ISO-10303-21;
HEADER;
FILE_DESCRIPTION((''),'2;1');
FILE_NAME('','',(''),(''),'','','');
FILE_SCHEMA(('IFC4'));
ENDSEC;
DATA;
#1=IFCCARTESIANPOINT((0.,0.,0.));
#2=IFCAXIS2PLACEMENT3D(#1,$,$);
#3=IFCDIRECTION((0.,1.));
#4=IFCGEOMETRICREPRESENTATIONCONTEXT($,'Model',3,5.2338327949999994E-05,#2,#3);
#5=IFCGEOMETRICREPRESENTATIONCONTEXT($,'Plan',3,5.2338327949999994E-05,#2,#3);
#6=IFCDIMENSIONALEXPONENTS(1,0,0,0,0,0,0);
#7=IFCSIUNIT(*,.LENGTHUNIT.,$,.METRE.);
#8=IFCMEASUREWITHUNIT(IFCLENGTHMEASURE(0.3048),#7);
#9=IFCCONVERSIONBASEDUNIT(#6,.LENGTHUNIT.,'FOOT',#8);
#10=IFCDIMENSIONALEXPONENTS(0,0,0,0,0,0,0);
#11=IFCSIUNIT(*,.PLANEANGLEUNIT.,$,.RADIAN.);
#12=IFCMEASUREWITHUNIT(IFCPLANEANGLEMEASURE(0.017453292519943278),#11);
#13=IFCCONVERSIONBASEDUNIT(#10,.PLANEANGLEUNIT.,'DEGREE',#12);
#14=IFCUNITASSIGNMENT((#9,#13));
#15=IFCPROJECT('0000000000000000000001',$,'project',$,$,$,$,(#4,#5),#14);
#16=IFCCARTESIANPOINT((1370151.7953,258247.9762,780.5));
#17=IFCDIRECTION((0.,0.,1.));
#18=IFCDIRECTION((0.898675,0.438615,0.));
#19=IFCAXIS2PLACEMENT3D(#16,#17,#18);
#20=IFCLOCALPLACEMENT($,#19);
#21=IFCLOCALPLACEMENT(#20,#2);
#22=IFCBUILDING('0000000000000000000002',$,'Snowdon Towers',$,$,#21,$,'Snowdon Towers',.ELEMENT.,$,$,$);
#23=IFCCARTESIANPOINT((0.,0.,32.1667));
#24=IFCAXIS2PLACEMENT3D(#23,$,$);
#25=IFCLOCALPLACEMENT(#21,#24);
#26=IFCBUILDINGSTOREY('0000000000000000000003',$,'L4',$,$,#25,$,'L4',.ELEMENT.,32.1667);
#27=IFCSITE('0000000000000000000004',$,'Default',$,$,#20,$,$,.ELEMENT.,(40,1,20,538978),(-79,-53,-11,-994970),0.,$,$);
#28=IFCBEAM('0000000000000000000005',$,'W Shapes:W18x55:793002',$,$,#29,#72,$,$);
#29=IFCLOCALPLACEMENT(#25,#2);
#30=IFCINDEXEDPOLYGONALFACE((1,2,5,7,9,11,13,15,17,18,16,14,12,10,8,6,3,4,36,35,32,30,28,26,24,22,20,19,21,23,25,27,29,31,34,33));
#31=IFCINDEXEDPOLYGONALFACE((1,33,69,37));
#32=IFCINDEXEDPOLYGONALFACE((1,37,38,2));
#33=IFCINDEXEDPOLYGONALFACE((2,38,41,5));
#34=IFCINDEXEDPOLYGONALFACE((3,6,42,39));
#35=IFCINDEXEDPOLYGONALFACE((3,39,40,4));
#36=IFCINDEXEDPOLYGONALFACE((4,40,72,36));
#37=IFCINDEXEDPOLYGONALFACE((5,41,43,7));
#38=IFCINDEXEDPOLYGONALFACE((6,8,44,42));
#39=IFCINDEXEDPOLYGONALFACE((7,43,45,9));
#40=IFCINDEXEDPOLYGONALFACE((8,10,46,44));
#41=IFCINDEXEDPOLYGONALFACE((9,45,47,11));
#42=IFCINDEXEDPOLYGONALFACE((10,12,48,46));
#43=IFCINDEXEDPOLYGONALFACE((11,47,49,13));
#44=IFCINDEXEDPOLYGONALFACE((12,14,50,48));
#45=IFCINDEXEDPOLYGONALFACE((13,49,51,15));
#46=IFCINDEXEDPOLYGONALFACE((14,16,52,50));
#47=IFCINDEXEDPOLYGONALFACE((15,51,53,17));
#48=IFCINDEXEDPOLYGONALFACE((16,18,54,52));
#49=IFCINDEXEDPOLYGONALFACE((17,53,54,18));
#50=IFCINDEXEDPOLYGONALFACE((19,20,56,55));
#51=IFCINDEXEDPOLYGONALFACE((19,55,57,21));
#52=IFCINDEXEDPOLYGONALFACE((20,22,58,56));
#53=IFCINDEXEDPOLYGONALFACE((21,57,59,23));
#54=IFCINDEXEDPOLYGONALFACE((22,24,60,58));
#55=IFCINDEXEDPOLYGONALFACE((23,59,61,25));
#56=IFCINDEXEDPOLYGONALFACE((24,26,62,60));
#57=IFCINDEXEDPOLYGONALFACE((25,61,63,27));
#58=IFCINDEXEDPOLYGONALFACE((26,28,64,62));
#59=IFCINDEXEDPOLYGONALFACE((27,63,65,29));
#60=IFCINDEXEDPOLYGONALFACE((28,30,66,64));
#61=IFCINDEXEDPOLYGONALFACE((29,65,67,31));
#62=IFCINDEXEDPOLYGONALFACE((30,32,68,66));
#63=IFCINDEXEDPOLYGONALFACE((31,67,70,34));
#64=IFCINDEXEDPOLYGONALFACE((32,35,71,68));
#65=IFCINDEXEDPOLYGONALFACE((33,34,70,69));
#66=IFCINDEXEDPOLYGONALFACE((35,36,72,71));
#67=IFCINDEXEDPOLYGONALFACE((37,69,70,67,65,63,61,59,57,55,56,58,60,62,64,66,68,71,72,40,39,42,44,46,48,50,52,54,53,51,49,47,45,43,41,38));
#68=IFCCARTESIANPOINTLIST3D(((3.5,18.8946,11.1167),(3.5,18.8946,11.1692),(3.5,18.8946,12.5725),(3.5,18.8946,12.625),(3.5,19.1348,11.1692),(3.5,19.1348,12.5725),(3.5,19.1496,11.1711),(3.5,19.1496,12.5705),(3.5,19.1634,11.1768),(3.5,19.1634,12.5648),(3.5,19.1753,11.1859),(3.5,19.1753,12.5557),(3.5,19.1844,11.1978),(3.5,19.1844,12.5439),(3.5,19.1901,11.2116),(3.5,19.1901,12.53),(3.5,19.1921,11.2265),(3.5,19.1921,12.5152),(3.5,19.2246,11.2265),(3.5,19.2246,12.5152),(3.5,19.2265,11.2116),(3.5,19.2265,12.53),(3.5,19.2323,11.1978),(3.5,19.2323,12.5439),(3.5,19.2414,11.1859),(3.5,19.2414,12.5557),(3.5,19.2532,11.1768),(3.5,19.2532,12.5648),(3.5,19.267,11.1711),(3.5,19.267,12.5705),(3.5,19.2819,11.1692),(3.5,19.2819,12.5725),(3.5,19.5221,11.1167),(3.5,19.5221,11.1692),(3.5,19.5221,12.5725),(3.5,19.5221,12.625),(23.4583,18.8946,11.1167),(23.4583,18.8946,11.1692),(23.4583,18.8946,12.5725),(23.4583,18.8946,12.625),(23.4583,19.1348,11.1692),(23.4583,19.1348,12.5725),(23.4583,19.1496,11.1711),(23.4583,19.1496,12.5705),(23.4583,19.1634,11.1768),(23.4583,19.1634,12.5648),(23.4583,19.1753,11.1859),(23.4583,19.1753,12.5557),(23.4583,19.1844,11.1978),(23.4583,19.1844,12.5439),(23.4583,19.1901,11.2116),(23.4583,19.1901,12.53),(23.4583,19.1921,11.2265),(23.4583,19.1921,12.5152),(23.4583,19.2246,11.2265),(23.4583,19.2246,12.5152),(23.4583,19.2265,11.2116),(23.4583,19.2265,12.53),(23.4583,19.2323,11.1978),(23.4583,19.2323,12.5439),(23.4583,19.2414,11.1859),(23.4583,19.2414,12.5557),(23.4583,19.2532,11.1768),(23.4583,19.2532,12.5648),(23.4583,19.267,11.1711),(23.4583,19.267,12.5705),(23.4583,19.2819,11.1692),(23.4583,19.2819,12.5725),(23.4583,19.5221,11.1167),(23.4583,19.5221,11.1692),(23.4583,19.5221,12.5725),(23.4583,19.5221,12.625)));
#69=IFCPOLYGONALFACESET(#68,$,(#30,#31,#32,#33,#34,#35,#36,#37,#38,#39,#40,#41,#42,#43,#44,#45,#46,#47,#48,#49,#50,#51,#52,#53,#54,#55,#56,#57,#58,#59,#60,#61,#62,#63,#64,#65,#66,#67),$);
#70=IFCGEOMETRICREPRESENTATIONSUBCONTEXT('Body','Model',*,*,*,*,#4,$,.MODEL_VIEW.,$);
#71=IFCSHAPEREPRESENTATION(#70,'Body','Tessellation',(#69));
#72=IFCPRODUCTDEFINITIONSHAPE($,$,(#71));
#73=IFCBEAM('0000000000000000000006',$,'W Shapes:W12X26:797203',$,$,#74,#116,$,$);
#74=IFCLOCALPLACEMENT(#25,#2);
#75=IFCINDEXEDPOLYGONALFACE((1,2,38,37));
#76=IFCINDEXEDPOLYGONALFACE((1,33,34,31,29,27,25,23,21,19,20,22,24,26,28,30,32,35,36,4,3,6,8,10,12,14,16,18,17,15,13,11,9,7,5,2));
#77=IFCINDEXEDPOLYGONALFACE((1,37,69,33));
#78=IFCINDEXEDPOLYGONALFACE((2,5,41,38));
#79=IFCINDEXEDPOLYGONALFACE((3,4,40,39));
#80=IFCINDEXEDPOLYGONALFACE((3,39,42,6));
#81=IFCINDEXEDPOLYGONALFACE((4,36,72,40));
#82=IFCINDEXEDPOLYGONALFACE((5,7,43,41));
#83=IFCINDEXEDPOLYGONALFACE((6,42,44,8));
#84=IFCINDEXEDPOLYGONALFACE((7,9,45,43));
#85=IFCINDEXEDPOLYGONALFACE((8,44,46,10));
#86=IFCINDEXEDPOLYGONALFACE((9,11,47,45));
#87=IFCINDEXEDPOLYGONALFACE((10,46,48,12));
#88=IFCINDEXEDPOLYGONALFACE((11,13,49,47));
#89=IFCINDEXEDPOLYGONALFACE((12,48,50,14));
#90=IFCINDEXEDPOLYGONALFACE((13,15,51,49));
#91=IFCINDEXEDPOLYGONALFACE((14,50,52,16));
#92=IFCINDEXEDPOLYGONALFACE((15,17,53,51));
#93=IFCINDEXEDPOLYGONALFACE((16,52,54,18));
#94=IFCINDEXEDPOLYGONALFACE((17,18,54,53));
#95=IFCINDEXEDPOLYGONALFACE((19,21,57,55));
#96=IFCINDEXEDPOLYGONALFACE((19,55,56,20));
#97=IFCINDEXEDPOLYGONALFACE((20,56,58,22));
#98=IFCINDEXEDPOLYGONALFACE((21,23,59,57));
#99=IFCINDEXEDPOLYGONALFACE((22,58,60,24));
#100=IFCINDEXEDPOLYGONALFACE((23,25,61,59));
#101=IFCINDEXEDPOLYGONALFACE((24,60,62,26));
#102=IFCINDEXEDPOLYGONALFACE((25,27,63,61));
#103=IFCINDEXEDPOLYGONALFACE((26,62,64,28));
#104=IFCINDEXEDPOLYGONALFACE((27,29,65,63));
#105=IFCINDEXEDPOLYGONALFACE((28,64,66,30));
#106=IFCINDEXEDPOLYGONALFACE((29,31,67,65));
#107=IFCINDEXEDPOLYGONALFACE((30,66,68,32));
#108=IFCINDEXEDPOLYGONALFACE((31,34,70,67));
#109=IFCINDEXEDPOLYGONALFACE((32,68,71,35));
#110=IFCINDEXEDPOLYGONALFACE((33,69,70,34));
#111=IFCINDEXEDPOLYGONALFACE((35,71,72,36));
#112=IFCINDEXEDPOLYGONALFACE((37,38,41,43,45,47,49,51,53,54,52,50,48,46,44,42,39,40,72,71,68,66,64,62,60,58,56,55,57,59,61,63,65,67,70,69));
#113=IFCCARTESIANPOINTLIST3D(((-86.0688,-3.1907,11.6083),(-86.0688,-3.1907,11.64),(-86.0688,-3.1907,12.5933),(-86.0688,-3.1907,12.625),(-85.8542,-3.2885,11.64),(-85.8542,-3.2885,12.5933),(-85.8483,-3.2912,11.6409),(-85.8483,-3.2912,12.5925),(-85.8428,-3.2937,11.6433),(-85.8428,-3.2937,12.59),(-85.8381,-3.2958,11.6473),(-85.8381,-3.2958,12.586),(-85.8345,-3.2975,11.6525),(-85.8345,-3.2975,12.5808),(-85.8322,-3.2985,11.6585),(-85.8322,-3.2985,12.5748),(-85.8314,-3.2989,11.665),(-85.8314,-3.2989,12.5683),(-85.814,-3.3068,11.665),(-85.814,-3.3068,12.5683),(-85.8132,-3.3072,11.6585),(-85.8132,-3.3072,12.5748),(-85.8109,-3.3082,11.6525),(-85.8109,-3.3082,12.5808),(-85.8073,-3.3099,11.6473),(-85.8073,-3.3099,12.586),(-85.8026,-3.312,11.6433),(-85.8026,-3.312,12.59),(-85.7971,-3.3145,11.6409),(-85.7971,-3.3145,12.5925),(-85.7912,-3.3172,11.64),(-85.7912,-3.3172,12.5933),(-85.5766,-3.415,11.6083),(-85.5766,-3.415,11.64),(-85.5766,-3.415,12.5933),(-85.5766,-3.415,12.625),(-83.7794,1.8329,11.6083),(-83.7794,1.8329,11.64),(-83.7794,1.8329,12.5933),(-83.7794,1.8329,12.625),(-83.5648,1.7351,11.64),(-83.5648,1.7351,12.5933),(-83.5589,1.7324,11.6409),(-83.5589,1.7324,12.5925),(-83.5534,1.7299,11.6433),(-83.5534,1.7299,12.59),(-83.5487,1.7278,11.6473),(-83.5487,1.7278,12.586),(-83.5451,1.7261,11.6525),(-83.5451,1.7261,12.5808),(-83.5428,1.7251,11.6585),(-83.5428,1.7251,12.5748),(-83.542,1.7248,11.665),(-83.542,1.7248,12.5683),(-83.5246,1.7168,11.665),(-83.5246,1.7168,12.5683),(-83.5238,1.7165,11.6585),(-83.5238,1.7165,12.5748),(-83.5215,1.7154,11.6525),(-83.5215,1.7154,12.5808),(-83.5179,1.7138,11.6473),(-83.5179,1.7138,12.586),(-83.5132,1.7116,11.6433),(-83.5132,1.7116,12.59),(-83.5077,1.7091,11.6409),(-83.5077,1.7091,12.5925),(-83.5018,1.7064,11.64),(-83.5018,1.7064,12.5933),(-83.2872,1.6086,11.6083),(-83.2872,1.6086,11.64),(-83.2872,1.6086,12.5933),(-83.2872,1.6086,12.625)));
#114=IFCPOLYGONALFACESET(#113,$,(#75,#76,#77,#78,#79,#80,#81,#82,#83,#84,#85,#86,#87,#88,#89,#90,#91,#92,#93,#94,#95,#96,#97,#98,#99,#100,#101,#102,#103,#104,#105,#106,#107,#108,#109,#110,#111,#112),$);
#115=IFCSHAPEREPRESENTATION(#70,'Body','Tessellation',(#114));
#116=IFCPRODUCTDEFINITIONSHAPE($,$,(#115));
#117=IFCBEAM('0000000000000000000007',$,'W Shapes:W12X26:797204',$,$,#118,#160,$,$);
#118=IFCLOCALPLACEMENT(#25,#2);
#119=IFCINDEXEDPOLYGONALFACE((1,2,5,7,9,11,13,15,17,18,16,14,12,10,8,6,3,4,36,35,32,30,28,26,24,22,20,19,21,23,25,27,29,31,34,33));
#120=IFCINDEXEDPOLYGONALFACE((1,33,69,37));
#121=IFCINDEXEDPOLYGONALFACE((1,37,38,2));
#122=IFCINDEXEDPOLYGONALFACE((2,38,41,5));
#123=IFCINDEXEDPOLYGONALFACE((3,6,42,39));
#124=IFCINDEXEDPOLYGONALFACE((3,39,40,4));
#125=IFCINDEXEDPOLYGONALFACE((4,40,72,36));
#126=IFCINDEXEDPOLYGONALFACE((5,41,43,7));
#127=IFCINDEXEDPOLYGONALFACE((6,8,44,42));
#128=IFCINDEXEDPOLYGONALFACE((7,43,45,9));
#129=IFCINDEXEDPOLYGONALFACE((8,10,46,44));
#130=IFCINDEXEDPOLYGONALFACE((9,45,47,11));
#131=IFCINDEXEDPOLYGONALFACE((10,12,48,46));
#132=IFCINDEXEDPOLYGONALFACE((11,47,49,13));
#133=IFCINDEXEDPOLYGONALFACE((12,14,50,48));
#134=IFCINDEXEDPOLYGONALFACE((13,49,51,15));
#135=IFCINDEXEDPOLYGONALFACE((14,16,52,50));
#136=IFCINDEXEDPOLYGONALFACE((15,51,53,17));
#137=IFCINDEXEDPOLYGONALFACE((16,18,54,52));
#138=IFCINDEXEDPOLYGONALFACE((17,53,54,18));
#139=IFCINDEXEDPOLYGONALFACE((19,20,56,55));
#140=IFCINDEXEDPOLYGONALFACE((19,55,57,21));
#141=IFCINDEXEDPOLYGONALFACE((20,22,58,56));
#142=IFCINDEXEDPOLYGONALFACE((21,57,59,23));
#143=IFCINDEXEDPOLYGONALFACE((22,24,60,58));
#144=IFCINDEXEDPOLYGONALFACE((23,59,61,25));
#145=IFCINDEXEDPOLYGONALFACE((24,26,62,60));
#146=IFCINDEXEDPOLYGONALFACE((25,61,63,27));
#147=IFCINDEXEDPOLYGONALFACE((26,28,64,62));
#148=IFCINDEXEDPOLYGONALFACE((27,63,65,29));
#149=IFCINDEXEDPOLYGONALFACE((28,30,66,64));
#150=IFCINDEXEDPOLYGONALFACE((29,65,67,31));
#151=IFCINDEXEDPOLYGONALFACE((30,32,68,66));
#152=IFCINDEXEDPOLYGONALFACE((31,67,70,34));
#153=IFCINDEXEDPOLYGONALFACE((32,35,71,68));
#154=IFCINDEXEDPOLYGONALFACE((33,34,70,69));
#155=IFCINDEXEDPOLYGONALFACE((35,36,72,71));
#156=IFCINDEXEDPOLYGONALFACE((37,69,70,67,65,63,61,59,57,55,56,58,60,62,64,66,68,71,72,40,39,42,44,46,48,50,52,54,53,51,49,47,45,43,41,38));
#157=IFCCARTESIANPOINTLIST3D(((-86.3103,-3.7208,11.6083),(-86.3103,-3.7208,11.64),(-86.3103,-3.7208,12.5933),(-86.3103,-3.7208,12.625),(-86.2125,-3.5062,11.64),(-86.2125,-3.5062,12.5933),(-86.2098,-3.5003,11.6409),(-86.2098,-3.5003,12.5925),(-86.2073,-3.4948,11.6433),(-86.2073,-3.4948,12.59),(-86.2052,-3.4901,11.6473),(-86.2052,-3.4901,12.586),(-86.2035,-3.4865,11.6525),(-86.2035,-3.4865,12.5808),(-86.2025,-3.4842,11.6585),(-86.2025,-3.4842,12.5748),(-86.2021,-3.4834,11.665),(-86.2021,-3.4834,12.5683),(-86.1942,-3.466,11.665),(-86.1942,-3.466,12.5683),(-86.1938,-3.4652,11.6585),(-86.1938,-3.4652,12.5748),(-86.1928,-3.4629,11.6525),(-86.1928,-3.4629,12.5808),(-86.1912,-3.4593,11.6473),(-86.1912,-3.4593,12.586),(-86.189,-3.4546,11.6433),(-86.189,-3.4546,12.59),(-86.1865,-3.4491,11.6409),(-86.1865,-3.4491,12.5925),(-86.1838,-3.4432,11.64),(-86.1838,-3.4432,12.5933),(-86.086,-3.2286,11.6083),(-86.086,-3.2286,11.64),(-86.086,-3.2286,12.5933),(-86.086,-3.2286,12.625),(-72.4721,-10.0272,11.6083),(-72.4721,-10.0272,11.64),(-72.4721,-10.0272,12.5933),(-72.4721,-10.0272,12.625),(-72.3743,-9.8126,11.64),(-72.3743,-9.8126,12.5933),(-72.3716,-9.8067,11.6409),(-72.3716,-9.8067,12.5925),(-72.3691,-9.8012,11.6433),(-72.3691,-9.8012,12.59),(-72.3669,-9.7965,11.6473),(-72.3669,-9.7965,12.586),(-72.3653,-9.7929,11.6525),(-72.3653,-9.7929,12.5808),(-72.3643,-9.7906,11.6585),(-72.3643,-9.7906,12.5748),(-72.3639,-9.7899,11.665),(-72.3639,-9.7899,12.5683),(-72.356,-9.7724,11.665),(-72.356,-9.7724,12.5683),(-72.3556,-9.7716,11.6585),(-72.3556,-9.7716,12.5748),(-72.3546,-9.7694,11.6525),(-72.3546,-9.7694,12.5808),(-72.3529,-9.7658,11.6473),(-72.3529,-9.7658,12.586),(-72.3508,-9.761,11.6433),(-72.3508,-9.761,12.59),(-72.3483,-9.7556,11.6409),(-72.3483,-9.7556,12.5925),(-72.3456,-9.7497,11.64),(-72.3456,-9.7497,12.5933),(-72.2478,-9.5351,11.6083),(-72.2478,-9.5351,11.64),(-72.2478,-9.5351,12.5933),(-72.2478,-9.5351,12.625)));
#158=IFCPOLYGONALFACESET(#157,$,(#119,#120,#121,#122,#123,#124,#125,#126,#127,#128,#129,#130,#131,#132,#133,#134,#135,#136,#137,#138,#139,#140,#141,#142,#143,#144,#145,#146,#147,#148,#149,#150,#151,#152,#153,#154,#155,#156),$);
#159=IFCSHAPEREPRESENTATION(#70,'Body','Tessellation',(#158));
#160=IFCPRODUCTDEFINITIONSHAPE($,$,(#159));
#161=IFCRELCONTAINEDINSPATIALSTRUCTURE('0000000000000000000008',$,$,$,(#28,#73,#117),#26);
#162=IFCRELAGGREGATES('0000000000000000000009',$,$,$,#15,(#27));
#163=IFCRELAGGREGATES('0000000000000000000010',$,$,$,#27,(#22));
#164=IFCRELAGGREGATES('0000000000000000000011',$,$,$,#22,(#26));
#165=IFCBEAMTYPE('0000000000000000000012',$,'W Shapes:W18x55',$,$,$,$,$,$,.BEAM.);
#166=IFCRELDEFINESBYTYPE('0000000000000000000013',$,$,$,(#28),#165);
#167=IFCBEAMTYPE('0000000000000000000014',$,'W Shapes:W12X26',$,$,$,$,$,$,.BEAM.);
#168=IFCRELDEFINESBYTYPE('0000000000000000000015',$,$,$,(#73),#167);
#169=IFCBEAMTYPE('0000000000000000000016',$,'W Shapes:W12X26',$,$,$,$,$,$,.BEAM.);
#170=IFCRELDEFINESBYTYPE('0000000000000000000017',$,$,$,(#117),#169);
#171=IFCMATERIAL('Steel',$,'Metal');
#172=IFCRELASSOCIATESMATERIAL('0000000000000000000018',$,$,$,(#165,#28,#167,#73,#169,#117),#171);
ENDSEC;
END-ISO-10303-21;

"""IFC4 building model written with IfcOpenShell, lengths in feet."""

from ifc_helpers import new_model, entity, si_unit, converted_unit, direction, frame, origin, place, context, subcontext, project, spatial, line, arc, indexed_curve, outline, extrude, source, transform, mapped, material, type_object, type_shapes, element, save


model = new_model("IFC4")

# Units and contexts
model_context = context("Model", 3, precision=5.2338327949999994e-05, world=origin(), true_north=direction((0.0, 1.0)))
plan_context = context("Plan", 3, precision=5.2338327949999994e-05, world=origin(), true_north=direction((0.0, 1.0)))
body_context = subcontext(model_context, "Body", "Model", "MODEL_VIEW")
ifc_project = project(units=[converted_unit("LENGTHUNIT", "FOOT", entity("IfcLengthMeasure", 0.3048), si_unit("LENGTHUNIT", "METRE"), dimensions=[1, 0, 0, 0, 0, 0, 0]), converted_unit("PLANEANGLEUNIT", "DEGREE", entity("IfcPlaneAngleMeasure", 0.017453292519943278), si_unit("PLANEANGLEUNIT", "RADIAN"), dimensions=[0, 0, 0, 0, 0, 0, 0])], contexts=[model_context, plan_context])

# Site, building, storey
site_placement = place(None, frame((1370151.7953, 258247.9762, 780.5), z_axis=(0.0, 0.0, 1.0), x_axis=(0.898675, 0.438615, 0.0)))
site = spatial("IfcSite", under=ifc_project, at=site_placement, Name="Default", CompositionType="ELEMENT", RefLatitude=(40, 1, 20, 538978), RefLongitude=(-79, -53, -11, -994970), RefElevation=0.0)
building_placement = place(site_placement, origin())
building = spatial("IfcBuilding", under=site, at=building_placement, Name="Snowdon Towers", LongName="Snowdon Towers", CompositionType="ELEMENT")
storey_placement = place(building_placement, frame((0.0, 0.0, 32.1667)))
storey = spatial("IfcBuildingStorey", under=building, at=storey_placement, Name="L4", LongName="L4", CompositionType="ELEMENT", Elevation=32.1667)

# Beams
ifc_material = material(Name="Steel", Category="Metal")
beam_type_1 = type_object("IfcBeamType", Name="W Shapes:W18x55", PredefinedType="BEAM", material=ifc_material)
shared_shape_1 = source(origin(), body_context, "Body", "SweptSolid", [
    extrude(outline(indexed_curve([(-0.7542, -0.3138), (-0.7017, -0.3138), (-0.7017, -0.0735), (-0.6849, -0.033), (-0.6444, -0.0162), (0.6444, -0.0162), (0.6849, -0.033), (0.7017, -0.0735), (0.7017, -0.3138), (0.7542, -0.3138), (0.7542, 0.3138), (0.7017, 0.3138), (0.7017, 0.0735), (0.6849, 0.033), (0.6444, 0.0163), (-0.6444, 0.0163), (-0.6849, 0.033), (-0.7017, 0.0735), (-0.7017, 0.3137), (-0.7542, 0.3137)], segments=[line(1, 2, 3), arc(3, 4, 5), line(5, 6), arc(6, 7, 8), line(8, 9, 10, 11, 12, 13), arc(13, 14, 15), line(15, 16), arc(16, 17, 18), line(18, 19, 20, 1)], self_intersect=False)), frame((-10.2083, 0.0, 0.0), z_axis=(1.0, 0.0, 0.0), x_axis=(0.0, 0.0, -1.0)), (0.0, 0.0, 1.0), 19.9583),
])
type_shapes(beam_type_1, [shared_shape_1])
beam_1_placement = place(storey_placement, frame((13.7083, 19.2083, 11.8708)))
element("IfcBeam", 1, at=beam_1_placement, inside=storey, type_object=beam_type_1, material=ifc_material, Name="W Shapes:W18x55:793002", context=body_context, shape_type="MappedRepresentation", body=[
    mapped(shared_shape_1, transform((0.0, 0.0, 0.0), scale=1.0)),
])
beam_type_2 = type_object("IfcBeamType", Name="W Shapes:W12X26", PredefinedType="BEAM", material=ifc_material)
shared_shape_2 = source(origin(), body_context, "Body", "SweptSolid", [
    extrude(outline(indexed_curve([(0.4767, -0.2704), (0.5083, -0.2704), (0.5083, 0.2704), (0.4767, 0.2704), (0.4767, 0.0346), (0.4693, 0.0169), (0.4517, 0.0096), (-0.4517, 0.0096), (-0.4693, 0.0169), (-0.4767, 0.0346), (-0.4767, 0.2704), (-0.5083, 0.2704), (-0.5083, -0.2704), (-0.4767, -0.2704), (-0.4767, -0.0346), (-0.4693, -0.0169), (-0.4517, -0.0096), (0.4517, -0.0096), (0.4693, -0.0169), (0.4767, -0.0346)], segments=[line(1, 2, 3, 4, 5), arc(5, 6, 7), line(7, 8), arc(8, 9, 10), line(10, 11, 12, 13, 14, 15), arc(15, 16, 17), line(17, 18), arc(18, 19, 20), line(20, 1)], self_intersect=False)), frame((-85.8227, -3.3028, 44.2833), z_axis=(0.414693, 0.909961, 0.0), x_axis=(0.0, 0.0, 1.0)), (0.0, 0.0, 1.0), 5.5207),
])
type_shapes(beam_type_2, [shared_shape_2])
beam_2_placement = place(storey_placement, frame((0.0, 0.0, -32.1667)))
element("IfcBeam", 2, at=beam_2_placement, inside=storey, type_object=beam_type_2, material=ifc_material, Name="W Shapes:W12X26:797203", context=body_context, shape_type="MappedRepresentation", body=[
    mapped(shared_shape_2, transform((0.0, 0.0, 0.0), scale=1.0)),
])
beam_type_3 = type_object("IfcBeamType", Name="W Shapes:W12X26", PredefinedType="BEAM", material=ifc_material)
shared_shape_3 = source(origin(), body_context, "Body", "SweptSolid", [
    extrude(outline(indexed_curve([(-0.5083, -0.2704), (-0.4767, -0.2704), (-0.4767, -0.0346), (-0.4693, -0.0169), (-0.4517, -0.0096), (0.4517, -0.0096), (0.4693, -0.0169), (0.4767, -0.0346), (0.4767, -0.2704), (0.5083, -0.2704), (0.5083, 0.2704), (0.4767, 0.2704), (0.4767, 0.0346), (0.4693, 0.0169), (0.4517, 0.0096), (-0.4517, 0.0096), (-0.4693, 0.0169), (-0.4767, 0.0346), (-0.4767, 0.2704), (-0.5083, 0.2704)], segments=[line(1, 2, 3), arc(3, 4, 5), line(5, 6), arc(6, 7, 8), line(8, 9, 10, 11, 12, 13), arc(13, 14, 15), line(15, 16), arc(16, 17, 18), line(18, 19, 20, 1)], self_intersect=False)), frame((-86.1982, -3.4747, 44.2833), z_axis=(0.909961, -0.414693, 0.0), x_axis=(0.0, 0.0, -1.0)), (0.0, 0.0, 1.0), 15.2075),
])
type_shapes(beam_type_3, [shared_shape_3])
beam_3_placement = place(storey_placement, frame((0.0, 0.0, -32.1667)))
element("IfcBeam", 3, at=beam_3_placement, inside=storey, type_object=beam_type_3, material=ifc_material, Name="W Shapes:W12X26:797204", context=body_context, shape_type="MappedRepresentation", body=[
    mapped(shared_shape_3, transform((0.0, 0.0, 0.0), scale=1.0)),
])

save(model, "model.ifc")
